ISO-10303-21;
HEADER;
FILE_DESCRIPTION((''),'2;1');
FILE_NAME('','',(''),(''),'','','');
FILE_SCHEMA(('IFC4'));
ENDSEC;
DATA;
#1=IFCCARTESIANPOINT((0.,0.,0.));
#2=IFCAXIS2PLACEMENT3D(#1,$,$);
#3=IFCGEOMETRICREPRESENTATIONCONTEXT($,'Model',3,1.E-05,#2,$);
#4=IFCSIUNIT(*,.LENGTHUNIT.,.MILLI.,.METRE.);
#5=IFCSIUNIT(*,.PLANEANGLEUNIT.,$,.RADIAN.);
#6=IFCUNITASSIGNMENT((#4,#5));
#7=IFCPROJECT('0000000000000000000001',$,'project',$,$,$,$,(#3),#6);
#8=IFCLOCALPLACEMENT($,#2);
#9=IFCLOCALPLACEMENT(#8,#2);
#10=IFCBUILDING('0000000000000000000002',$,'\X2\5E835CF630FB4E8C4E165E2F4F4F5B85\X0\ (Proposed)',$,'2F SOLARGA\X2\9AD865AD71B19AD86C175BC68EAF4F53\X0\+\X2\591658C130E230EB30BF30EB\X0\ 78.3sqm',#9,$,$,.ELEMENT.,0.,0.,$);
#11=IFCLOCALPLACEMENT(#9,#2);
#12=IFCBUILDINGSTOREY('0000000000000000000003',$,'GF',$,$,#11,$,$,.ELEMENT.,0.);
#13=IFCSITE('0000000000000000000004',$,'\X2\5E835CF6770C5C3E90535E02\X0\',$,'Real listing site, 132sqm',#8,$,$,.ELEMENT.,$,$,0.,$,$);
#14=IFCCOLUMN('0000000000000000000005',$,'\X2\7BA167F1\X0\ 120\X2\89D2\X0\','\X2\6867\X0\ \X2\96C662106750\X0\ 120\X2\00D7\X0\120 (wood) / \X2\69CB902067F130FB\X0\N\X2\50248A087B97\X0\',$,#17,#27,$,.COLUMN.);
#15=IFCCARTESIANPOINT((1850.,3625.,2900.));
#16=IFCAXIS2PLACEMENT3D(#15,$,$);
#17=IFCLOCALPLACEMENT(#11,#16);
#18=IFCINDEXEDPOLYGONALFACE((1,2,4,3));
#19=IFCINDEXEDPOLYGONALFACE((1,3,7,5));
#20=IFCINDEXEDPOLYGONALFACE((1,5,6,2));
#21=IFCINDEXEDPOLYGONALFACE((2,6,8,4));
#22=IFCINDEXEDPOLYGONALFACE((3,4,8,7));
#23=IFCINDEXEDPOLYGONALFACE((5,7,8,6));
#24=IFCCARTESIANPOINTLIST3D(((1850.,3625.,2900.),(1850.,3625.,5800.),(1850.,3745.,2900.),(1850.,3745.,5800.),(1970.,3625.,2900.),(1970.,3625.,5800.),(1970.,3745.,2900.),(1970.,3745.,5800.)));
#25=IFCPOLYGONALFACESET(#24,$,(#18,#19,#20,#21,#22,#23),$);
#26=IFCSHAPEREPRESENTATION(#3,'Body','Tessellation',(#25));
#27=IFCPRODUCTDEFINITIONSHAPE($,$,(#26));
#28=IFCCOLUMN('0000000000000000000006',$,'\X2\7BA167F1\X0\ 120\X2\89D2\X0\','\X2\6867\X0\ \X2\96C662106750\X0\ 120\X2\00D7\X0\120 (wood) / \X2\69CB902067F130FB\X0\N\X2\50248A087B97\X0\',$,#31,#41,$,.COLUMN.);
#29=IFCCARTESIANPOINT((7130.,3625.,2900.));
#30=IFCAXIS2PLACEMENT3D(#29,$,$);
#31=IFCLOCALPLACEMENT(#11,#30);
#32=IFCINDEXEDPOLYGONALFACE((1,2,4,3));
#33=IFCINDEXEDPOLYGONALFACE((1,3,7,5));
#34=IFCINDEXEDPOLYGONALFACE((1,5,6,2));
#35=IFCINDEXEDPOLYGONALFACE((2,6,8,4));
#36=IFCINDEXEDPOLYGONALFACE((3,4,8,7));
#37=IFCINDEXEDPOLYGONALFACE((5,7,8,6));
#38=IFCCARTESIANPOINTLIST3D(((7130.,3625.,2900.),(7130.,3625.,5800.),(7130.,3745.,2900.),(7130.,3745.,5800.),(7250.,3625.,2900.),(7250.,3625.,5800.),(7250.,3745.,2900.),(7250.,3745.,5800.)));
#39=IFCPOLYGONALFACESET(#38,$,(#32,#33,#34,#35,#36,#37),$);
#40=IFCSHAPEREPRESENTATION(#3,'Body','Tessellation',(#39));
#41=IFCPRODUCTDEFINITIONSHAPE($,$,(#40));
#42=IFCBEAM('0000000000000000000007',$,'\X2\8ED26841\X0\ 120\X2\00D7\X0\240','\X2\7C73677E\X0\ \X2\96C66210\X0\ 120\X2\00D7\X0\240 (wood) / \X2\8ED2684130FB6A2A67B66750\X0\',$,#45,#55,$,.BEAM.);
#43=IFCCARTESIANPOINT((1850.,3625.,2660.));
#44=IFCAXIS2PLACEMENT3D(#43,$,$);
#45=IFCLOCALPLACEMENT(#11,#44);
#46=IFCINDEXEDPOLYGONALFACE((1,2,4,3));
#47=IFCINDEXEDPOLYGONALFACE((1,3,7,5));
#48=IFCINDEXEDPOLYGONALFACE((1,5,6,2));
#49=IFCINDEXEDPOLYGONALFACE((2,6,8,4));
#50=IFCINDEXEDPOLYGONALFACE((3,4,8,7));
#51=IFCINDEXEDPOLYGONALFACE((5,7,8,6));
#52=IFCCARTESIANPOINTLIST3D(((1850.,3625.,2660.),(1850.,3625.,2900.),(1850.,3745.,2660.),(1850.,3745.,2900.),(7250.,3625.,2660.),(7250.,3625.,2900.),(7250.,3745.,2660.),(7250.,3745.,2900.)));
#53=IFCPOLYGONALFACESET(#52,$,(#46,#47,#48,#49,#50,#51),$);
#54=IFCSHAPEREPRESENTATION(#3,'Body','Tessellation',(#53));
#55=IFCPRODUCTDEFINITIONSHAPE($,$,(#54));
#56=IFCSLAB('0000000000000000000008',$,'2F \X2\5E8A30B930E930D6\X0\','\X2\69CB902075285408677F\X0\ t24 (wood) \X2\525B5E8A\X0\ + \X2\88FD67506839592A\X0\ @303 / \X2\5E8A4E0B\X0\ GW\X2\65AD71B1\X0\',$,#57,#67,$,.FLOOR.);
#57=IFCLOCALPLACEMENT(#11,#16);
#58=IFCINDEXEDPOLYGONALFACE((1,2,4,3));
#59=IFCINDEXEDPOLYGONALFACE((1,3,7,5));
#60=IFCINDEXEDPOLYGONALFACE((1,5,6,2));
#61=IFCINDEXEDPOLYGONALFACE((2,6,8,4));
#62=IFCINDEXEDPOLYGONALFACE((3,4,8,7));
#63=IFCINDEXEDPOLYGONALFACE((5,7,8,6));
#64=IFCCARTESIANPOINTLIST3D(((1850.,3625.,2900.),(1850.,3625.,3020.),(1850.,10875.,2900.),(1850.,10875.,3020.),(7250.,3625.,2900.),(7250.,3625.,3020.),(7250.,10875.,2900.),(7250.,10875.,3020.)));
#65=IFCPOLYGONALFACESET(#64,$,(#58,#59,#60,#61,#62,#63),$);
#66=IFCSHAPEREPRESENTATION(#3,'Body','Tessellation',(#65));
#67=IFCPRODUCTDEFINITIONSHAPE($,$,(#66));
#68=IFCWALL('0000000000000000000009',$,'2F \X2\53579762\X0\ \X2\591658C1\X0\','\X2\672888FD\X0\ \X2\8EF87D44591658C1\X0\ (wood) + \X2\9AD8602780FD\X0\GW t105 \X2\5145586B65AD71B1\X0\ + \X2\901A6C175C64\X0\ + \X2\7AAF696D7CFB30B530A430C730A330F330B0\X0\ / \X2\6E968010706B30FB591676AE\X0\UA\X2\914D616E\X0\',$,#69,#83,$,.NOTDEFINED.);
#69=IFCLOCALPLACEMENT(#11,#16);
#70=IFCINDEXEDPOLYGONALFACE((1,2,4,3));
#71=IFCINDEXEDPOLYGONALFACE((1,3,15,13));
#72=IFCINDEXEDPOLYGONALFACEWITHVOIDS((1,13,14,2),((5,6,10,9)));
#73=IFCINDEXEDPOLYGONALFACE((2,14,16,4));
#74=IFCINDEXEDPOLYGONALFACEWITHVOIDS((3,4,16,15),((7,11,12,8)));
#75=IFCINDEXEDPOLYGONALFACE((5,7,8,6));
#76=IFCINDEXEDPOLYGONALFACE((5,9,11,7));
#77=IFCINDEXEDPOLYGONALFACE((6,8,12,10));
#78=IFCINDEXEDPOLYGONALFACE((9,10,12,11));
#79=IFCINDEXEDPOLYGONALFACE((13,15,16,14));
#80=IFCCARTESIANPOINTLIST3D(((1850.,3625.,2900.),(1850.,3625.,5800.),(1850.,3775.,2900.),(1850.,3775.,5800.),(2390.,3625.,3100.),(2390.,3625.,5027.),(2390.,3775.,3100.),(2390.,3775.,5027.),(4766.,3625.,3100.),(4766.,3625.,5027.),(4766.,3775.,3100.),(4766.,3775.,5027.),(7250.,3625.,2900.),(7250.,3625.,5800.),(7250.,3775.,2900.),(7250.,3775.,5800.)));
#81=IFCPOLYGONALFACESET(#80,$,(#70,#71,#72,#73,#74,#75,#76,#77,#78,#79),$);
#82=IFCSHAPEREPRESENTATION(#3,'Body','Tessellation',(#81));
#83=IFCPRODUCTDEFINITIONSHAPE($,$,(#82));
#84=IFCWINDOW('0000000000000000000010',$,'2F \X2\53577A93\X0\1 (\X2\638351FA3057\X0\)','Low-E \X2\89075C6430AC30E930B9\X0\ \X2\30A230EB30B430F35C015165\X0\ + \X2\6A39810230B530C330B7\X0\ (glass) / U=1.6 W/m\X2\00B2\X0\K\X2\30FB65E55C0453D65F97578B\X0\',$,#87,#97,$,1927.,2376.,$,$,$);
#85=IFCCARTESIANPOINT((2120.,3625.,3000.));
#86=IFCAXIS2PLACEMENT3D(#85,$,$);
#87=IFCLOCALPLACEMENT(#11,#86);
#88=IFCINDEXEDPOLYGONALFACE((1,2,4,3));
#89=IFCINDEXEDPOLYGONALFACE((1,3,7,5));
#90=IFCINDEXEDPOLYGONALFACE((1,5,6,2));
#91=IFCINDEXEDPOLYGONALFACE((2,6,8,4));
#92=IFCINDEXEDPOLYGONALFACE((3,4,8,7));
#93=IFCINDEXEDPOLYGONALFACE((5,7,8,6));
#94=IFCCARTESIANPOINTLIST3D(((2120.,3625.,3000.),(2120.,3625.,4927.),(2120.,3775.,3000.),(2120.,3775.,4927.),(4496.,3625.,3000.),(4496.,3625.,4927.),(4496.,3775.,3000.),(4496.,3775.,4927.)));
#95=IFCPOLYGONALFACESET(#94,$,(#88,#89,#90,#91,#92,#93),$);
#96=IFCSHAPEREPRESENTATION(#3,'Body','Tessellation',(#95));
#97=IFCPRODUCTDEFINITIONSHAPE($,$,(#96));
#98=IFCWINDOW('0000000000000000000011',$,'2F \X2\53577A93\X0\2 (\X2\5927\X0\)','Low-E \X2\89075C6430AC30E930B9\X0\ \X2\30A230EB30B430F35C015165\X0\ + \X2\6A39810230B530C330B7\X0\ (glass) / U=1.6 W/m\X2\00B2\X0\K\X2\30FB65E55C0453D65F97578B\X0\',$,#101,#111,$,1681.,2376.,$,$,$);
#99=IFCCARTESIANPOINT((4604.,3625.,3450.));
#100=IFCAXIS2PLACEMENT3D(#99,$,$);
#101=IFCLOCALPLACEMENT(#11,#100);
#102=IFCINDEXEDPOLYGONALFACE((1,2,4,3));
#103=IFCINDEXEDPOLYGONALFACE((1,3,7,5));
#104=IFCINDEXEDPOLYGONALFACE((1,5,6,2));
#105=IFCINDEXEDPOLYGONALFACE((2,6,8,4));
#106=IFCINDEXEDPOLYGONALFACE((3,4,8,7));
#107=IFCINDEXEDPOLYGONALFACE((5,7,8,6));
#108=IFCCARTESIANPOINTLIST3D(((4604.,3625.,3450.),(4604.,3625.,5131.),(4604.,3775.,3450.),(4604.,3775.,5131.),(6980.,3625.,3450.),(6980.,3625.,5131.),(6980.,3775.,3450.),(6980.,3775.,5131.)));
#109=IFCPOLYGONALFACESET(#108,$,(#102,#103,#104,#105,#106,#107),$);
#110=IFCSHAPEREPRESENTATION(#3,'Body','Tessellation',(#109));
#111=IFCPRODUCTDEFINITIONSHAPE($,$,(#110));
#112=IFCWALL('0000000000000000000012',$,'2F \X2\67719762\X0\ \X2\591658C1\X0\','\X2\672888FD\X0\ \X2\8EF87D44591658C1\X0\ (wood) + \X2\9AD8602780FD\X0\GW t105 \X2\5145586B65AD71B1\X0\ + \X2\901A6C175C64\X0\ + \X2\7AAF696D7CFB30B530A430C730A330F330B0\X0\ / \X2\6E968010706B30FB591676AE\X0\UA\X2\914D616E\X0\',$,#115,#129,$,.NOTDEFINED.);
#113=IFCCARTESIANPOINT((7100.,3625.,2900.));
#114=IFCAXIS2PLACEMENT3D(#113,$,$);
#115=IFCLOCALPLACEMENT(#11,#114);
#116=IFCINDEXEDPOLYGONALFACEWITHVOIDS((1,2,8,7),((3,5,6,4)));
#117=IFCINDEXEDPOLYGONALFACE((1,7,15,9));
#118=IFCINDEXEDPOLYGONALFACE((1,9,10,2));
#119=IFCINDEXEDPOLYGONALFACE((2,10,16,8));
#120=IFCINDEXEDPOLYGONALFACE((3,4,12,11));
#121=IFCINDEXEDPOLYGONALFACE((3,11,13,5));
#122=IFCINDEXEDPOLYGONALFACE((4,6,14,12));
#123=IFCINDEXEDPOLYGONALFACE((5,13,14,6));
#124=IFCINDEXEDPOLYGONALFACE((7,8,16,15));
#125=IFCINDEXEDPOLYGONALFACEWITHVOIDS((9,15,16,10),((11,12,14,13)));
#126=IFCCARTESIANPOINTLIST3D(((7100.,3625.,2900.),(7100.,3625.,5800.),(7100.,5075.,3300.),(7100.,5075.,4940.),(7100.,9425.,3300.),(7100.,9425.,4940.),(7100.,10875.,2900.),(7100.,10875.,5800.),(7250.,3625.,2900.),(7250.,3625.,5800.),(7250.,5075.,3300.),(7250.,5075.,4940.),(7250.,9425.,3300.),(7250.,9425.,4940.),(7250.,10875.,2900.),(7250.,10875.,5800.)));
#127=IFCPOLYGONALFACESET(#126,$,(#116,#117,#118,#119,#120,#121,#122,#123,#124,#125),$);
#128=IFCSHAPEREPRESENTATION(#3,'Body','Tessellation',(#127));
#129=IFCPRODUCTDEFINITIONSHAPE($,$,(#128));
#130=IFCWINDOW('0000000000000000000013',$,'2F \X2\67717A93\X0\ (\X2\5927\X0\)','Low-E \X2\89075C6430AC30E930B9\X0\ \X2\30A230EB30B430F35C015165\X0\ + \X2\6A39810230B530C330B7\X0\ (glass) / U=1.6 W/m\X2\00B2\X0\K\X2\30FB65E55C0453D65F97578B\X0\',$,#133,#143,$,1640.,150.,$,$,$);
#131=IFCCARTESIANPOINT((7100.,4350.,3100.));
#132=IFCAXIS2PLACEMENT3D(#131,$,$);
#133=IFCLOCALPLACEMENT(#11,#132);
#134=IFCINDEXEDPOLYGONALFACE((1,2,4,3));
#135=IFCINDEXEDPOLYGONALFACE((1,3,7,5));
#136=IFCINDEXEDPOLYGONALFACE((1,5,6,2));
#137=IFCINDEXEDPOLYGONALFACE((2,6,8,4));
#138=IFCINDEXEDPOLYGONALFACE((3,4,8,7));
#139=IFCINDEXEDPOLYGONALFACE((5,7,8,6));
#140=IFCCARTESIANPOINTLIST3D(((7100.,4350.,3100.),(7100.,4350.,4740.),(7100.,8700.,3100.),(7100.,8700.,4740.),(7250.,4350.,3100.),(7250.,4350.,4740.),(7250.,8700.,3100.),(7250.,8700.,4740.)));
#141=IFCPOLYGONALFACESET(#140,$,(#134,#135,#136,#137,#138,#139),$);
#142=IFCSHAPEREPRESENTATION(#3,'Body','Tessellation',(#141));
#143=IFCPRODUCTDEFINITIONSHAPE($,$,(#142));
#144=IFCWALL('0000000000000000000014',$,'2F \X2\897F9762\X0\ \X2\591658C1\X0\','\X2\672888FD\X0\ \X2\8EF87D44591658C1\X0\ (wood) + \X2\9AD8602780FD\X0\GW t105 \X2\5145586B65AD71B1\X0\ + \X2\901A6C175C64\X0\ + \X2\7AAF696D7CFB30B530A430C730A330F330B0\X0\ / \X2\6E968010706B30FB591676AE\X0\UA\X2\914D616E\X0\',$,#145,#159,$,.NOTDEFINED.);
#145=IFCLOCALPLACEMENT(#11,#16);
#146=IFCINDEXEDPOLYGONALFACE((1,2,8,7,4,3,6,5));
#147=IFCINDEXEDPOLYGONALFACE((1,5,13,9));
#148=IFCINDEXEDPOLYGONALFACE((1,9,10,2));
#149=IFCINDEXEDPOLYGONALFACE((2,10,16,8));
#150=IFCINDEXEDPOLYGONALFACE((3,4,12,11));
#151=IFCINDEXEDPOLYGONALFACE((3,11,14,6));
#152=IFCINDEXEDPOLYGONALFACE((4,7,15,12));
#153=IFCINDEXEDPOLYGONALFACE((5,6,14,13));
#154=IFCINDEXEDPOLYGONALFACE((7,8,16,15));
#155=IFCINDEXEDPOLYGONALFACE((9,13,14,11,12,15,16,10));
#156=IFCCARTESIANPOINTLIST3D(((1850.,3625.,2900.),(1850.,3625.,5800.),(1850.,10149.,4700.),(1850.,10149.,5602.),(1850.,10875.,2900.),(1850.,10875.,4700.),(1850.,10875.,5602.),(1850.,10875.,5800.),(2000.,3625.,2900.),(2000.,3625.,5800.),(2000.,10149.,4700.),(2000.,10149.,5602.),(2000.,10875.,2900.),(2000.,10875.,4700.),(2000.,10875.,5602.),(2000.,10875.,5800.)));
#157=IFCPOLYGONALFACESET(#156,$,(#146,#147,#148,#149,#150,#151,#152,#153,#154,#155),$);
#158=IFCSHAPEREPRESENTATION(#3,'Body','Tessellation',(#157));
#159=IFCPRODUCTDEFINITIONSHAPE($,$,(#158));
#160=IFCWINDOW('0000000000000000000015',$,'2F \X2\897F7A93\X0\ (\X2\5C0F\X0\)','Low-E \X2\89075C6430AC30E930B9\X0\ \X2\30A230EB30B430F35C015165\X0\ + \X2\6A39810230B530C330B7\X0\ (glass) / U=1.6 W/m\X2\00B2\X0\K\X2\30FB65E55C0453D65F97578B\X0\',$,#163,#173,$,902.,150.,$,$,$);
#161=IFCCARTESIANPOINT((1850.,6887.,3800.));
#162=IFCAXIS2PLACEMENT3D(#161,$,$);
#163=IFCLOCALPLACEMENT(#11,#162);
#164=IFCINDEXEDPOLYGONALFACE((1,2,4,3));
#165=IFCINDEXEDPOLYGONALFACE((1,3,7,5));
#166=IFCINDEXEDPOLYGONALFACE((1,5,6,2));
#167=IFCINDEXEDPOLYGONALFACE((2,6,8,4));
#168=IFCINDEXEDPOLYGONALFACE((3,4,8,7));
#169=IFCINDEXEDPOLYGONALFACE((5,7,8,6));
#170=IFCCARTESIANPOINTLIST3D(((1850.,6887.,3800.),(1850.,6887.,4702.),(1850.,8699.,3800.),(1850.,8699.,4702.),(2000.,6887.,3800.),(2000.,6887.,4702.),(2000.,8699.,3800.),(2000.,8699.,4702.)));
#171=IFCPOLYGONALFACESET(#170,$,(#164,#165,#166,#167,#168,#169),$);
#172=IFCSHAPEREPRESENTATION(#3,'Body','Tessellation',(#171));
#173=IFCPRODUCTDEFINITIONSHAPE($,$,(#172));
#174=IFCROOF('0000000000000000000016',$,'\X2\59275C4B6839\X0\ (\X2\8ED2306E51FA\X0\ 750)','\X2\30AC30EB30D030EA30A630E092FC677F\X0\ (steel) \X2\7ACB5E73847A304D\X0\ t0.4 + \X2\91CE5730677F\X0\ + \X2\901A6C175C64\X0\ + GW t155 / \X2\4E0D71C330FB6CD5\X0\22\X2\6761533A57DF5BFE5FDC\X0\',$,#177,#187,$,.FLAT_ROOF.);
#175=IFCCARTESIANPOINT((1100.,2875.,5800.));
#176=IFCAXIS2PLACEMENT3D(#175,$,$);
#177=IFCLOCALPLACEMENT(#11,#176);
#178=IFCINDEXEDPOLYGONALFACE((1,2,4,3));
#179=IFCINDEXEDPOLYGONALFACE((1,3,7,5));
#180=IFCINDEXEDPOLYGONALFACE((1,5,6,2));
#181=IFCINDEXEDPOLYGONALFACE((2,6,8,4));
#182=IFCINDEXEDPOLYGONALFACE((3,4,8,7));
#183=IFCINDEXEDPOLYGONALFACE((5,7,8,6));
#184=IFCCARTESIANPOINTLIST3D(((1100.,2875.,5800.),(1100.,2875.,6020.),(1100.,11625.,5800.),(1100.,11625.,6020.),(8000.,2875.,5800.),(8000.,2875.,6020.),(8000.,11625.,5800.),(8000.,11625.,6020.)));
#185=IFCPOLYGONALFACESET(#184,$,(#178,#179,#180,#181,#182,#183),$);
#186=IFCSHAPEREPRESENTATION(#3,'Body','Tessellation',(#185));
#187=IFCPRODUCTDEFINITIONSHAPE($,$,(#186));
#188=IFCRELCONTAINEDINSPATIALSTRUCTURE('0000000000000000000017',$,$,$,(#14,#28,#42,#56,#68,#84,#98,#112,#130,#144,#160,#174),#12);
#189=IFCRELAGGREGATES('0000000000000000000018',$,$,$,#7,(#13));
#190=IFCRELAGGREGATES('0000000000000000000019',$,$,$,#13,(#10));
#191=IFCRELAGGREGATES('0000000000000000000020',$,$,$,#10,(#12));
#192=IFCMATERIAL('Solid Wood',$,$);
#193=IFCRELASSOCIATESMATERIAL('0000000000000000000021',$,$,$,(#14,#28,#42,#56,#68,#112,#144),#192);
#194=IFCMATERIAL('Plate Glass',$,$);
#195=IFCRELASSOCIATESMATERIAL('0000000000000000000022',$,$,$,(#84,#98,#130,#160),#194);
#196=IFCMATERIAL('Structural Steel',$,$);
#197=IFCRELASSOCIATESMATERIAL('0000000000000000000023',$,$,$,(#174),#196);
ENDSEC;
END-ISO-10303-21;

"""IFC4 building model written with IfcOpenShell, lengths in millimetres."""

from ifc_helpers import new_model, si_unit, frame, frame_2d, origin, place, context, project, spatial, rectangle, extrude, material, element, fill, save


model = new_model("IFC4")

# Units and contexts
model_context = context("Model", 3, precision=1e-05, world=origin())
ifc_project = project(units=[si_unit("LENGTHUNIT", "METRE", prefix="MILLI"), si_unit("PLANEANGLEUNIT", "RADIAN")], contexts=[model_context])

# Site, building, storey
site_placement = place(None, origin())
site = spatial("IfcSite", under=ifc_project, at=site_placement, Name="広島県尾道市", ObjectType="Real listing site, 132sqm", CompositionType="ELEMENT", RefElevation=0.0)
building_placement = place(site_placement, origin())
building = spatial("IfcBuilding", under=site, at=building_placement, Name="広島・二世帯住宅 (Proposed)", ObjectType="2F SOLARGA高断熱高気密躯体+外壁モルタル 78.3sqm", CompositionType="ELEMENT", ElevationOfRefHeight=0.0, ElevationOfTerrain=0.0)
storey_placement = place(building_placement, origin())
storey = spatial("IfcBuildingStorey", under=building, at=storey_placement, Name="GF", CompositionType="ELEMENT", Elevation=0.0)

# Columns
ifc_material_1 = material(Name="Solid Wood")
column_1_placement = place(storey_placement, frame((1850.0, 3625.0, 2900.0)))
element("IfcColumn", 1, at=column_1_placement, inside=storey, material=ifc_material_1, Name="管柱 120角", Description="桧 集成材 120×120 (wood) / 構造柱・N値計算", PredefinedType="COLUMN", context=model_context, shape_type="SweptSolid", body=[
    extrude(rectangle(XDim=120.0, YDim=120.0, at=frame_2d((60.0, 60.0))), frame((1850.0, 3625.0, 2900.0)), (0.0, 0.0, 1.0), 2900.0),
])
column_2_placement = place(storey_placement, frame((7130.0, 3625.0, 2900.0)))
element("IfcColumn", 2, at=column_2_placement, inside=storey, material=ifc_material_1, Name="管柱 120角", Description="桧 集成材 120×120 (wood) / 構造柱・N値計算", PredefinedType="COLUMN", context=model_context, shape_type="SweptSolid", body=[
    extrude(rectangle(XDim=120.0, YDim=120.0, at=frame_2d((60.0, 60.0))), frame((7130.0, 3625.0, 2900.0)), (0.0, 0.0, 1.0), 2900.0),
])

# Beam
beam_1_placement = place(storey_placement, frame((1850.0, 3625.0, 2660.0)))
element("IfcBeam", 3, at=beam_1_placement, inside=storey, material=ifc_material_1, Name="軒桁 120×240", Description="米松 集成 120×240 (wood) / 軒桁・横架材", PredefinedType="BEAM", context=model_context, shape_type="SweptSolid", body=[
    extrude(rectangle(XDim=5400.0, YDim=120.0, at=frame_2d((2700.0, 60.0))), frame((1850.0, 3625.0, 2660.0)), (0.0, 0.0, 1.0), 240.0),
])

# Slab
slab_placement = place(storey_placement, frame((1850.0, 3625.0, 2900.0)))
element("IfcSlab", 4, at=slab_placement, inside=storey, material=ifc_material_1, Name="2F 床スラブ", Description="構造用合板 t24 (wood) 剛床 + 製材根太 @303 / 床下 GW断熱", PredefinedType="FLOOR", context=model_context, shape_type="SweptSolid", body=[
    extrude(rectangle(XDim=5400.0, YDim=7250.0, at=frame_2d((2700.0, 3625.0))), frame((1850.0, 3625.0, 2900.0)), (0.0, 0.0, 1.0), 120.0),
])

# Wall, openings, windows
wall_1_placement = place(storey_placement, frame((1850.0, 3625.0, 2900.0)))
wall_1 = element("IfcWall", 5, at=wall_1_placement, inside=storey, material=ifc_material_1, Name="2F 南面 外壁", Description="木製 軸組外壁 (wood) + 高性能GW t105 充填断熱 + 通気層 + 窯業系サイディング / 準耐火・外皮UA配慮", PredefinedType="NOTDEFINED", context=model_context, shape_type="SweptSolid", body=[
    extrude(rectangle(XDim=5400.0, YDim=150.0, at=frame_2d((2700.0, 75.0))), frame((1850.0, 3625.0, 2900.0)), (0.0, 0.0, 1.0), 2900.0),
])
opening_1_placement = place(storey_placement, frame((2120.0, 3625.0, 3000.0)))
opening_1 = element("IfcOpeningElement", 6, at=opening_1_placement, cuts=wall_1, PredefinedType="NOTDEFINED", context=model_context, shape_type="SweptSolid", body=[
    extrude(rectangle(XDim=2376.0, YDim=150.0, at=frame_2d((1188.0, 75.0))), frame((2120.0, 3625.0, 3000.0)), (0.0, 0.0, 1.0), 1927.0),
])
opening_2_placement = place(storey_placement, frame((4604.0, 3625.0, 3450.0)))
opening_2 = element("IfcOpeningElement", 7, at=opening_2_placement, cuts=wall_1, PredefinedType="NOTDEFINED", context=model_context, shape_type="SweptSolid", body=[
    extrude(rectangle(XDim=2376.0, YDim=150.0, at=frame_2d((1188.0, 75.0))), frame((4604.0, 3625.0, 3450.0)), (0.0, 0.0, 1.0), 1681.0),
])
ifc_material_2 = material(Name="Plate Glass")
window_1_placement = place(storey_placement, frame((2120.0, 3625.0, 3000.0)))
window_1 = element("IfcWindow", 8, at=window_1_placement, inside=storey, material=ifc_material_2, Name="2F 南窓1 (掃出し)", Description="Low-E 複層ガラス アルゴン封入 + 樹脂サッシ (glass) / U=1.6 W/m²K・日射取得型", OverallHeight=1927.0, OverallWidth=2376.0, context=model_context, shape_type="SweptSolid", body=[
    extrude(rectangle(XDim=2376.0, YDim=150.0, at=frame_2d((1188.0, 75.0))), frame((2120.0, 3625.0, 3000.0)), (0.0, 0.0, 1.0), 1927.0),
])
fill(opening_1, window_1)
window_2_placement = place(storey_placement, frame((4604.0, 3625.0, 3450.0)))
window_2 = element("IfcWindow", 9, at=window_2_placement, inside=storey, material=ifc_material_2, Name="2F 南窓2 (大)", Description="Low-E 複層ガラス アルゴン封入 + 樹脂サッシ (glass) / U=1.6 W/m²K・日射取得型", OverallHeight=1681.0, OverallWidth=2376.0, context=model_context, shape_type="SweptSolid", body=[
    extrude(rectangle(XDim=2376.0, YDim=150.0, at=frame_2d((1188.0, 75.0))), frame((4604.0, 3625.0, 3450.0)), (0.0, 0.0, 1.0), 1681.0),
])
fill(opening_2, window_2)

# Walls, openings, windows
wall_2_placement = place(storey_placement, frame((7100.0, 3625.0, 2900.0)))
wall_2 = element("IfcWall", 10, at=wall_2_placement, inside=storey, material=ifc_material_1, Name="2F 東面 外壁", Description="木製 軸組外壁 (wood) + 高性能GW t105 充填断熱 + 通気層 + 窯業系サイディング / 準耐火・外皮UA配慮", PredefinedType="NOTDEFINED", context=model_context, shape_type="SweptSolid", body=[
    extrude(rectangle(XDim=150.0, YDim=7250.0, at=frame_2d((75.0, 3625.0))), frame((7100.0, 3625.0, 2900.0)), (0.0, 0.0, 1.0), 2900.0),
])
opening_3_placement = place(storey_placement, frame((7100.0, 4350.0, 3100.0)))
opening_3 = element("IfcOpeningElement", 11, at=opening_3_placement, cuts=wall_2, PredefinedType="NOTDEFINED", context=model_context, shape_type="SweptSolid", body=[
    extrude(rectangle(XDim=150.0, YDim=4350.0, at=frame_2d((75.0, 2175.0))), frame((7100.0, 4350.0, 3100.0)), (0.0, 0.0, 1.0), 1640.0),
])
window_3_placement = place(storey_placement, frame((7100.0, 4350.0, 3100.0)))
window_3 = element("IfcWindow", 12, at=window_3_placement, inside=storey, material=ifc_material_2, Name="2F 東窓 (大)", Description="Low-E 複層ガラス アルゴン封入 + 樹脂サッシ (glass) / U=1.6 W/m²K・日射取得型", OverallHeight=1640.0, OverallWidth=150.0, context=model_context, shape_type="SweptSolid", body=[
    extrude(rectangle(XDim=150.0, YDim=4350.0, at=frame_2d((75.0, 2175.0))), frame((7100.0, 4350.0, 3100.0)), (0.0, 0.0, 1.0), 1640.0),
])
fill(opening_3, window_3)
wall_3_placement = place(storey_placement, frame((1850.0, 3625.0, 2900.0)))
wall_3 = element("IfcWall", 13, at=wall_3_placement, inside=storey, material=ifc_material_1, Name="2F 西面 外壁", Description="木製 軸組外壁 (wood) + 高性能GW t105 充填断熱 + 通気層 + 窯業系サイディング / 準耐火・外皮UA配慮", PredefinedType="NOTDEFINED", context=model_context, shape_type="SweptSolid", body=[
    extrude(rectangle(XDim=150.0, YDim=7250.0, at=frame_2d((75.0, 3625.0))), frame((1850.0, 3625.0, 2900.0)), (0.0, 0.0, 1.0), 2900.0),
])
opening_4_placement = place(storey_placement, frame((1850.0, 6887.0, 3800.0)))
opening_4 = element("IfcOpeningElement", 14, at=opening_4_placement, cuts=wall_3, PredefinedType="NOTDEFINED", context=model_context, shape_type="SweptSolid", body=[
    extrude(rectangle(XDim=150.0, YDim=1812.0, at=frame_2d((75.0, 906.0))), frame((1850.0, 6887.0, 3800.0)), (0.0, 0.0, 1.0), 902.0),
])
window_4_placement = place(storey_placement, frame((1850.0, 6887.0, 3800.0)))
window_4 = element("IfcWindow", 15, at=window_4_placement, inside=storey, material=ifc_material_2, Name="2F 西窓 (小)", Description="Low-E 複層ガラス アルゴン封入 + 樹脂サッシ (glass) / U=1.6 W/m²K・日射取得型", OverallHeight=902.0, OverallWidth=150.0, context=model_context, shape_type="SweptSolid", body=[
    extrude(rectangle(XDim=150.0, YDim=1812.0, at=frame_2d((75.0, 906.0))), frame((1850.0, 6887.0, 3800.0)), (0.0, 0.0, 1.0), 902.0),
])
fill(opening_4, window_4)

# Roof
ifc_material_3 = material(Name="Structural Steel")
roof_placement = place(storey_placement, frame((1100.0, 2875.0, 5800.0)))
element("IfcRoof", 16, at=roof_placement, inside=storey, material=ifc_material_3, Name="大屋根 (軒の出 750)", Description="ガルバリウム鋼板 (steel) 立平葺き t0.4 + 野地板 + 通気層 + GW t155 / 不燃・法22条区域対応", PredefinedType="FLAT_ROOF", context=model_context, shape_type="SweptSolid", body=[
    extrude(rectangle(XDim=6900.0, YDim=8750.0, at=frame_2d((3450.0, 4375.0))), frame((1100.0, 2875.0, 5800.0)), (0.0, 0.0, 1.0), 220.0),
])

save(model, "model.ifc")
